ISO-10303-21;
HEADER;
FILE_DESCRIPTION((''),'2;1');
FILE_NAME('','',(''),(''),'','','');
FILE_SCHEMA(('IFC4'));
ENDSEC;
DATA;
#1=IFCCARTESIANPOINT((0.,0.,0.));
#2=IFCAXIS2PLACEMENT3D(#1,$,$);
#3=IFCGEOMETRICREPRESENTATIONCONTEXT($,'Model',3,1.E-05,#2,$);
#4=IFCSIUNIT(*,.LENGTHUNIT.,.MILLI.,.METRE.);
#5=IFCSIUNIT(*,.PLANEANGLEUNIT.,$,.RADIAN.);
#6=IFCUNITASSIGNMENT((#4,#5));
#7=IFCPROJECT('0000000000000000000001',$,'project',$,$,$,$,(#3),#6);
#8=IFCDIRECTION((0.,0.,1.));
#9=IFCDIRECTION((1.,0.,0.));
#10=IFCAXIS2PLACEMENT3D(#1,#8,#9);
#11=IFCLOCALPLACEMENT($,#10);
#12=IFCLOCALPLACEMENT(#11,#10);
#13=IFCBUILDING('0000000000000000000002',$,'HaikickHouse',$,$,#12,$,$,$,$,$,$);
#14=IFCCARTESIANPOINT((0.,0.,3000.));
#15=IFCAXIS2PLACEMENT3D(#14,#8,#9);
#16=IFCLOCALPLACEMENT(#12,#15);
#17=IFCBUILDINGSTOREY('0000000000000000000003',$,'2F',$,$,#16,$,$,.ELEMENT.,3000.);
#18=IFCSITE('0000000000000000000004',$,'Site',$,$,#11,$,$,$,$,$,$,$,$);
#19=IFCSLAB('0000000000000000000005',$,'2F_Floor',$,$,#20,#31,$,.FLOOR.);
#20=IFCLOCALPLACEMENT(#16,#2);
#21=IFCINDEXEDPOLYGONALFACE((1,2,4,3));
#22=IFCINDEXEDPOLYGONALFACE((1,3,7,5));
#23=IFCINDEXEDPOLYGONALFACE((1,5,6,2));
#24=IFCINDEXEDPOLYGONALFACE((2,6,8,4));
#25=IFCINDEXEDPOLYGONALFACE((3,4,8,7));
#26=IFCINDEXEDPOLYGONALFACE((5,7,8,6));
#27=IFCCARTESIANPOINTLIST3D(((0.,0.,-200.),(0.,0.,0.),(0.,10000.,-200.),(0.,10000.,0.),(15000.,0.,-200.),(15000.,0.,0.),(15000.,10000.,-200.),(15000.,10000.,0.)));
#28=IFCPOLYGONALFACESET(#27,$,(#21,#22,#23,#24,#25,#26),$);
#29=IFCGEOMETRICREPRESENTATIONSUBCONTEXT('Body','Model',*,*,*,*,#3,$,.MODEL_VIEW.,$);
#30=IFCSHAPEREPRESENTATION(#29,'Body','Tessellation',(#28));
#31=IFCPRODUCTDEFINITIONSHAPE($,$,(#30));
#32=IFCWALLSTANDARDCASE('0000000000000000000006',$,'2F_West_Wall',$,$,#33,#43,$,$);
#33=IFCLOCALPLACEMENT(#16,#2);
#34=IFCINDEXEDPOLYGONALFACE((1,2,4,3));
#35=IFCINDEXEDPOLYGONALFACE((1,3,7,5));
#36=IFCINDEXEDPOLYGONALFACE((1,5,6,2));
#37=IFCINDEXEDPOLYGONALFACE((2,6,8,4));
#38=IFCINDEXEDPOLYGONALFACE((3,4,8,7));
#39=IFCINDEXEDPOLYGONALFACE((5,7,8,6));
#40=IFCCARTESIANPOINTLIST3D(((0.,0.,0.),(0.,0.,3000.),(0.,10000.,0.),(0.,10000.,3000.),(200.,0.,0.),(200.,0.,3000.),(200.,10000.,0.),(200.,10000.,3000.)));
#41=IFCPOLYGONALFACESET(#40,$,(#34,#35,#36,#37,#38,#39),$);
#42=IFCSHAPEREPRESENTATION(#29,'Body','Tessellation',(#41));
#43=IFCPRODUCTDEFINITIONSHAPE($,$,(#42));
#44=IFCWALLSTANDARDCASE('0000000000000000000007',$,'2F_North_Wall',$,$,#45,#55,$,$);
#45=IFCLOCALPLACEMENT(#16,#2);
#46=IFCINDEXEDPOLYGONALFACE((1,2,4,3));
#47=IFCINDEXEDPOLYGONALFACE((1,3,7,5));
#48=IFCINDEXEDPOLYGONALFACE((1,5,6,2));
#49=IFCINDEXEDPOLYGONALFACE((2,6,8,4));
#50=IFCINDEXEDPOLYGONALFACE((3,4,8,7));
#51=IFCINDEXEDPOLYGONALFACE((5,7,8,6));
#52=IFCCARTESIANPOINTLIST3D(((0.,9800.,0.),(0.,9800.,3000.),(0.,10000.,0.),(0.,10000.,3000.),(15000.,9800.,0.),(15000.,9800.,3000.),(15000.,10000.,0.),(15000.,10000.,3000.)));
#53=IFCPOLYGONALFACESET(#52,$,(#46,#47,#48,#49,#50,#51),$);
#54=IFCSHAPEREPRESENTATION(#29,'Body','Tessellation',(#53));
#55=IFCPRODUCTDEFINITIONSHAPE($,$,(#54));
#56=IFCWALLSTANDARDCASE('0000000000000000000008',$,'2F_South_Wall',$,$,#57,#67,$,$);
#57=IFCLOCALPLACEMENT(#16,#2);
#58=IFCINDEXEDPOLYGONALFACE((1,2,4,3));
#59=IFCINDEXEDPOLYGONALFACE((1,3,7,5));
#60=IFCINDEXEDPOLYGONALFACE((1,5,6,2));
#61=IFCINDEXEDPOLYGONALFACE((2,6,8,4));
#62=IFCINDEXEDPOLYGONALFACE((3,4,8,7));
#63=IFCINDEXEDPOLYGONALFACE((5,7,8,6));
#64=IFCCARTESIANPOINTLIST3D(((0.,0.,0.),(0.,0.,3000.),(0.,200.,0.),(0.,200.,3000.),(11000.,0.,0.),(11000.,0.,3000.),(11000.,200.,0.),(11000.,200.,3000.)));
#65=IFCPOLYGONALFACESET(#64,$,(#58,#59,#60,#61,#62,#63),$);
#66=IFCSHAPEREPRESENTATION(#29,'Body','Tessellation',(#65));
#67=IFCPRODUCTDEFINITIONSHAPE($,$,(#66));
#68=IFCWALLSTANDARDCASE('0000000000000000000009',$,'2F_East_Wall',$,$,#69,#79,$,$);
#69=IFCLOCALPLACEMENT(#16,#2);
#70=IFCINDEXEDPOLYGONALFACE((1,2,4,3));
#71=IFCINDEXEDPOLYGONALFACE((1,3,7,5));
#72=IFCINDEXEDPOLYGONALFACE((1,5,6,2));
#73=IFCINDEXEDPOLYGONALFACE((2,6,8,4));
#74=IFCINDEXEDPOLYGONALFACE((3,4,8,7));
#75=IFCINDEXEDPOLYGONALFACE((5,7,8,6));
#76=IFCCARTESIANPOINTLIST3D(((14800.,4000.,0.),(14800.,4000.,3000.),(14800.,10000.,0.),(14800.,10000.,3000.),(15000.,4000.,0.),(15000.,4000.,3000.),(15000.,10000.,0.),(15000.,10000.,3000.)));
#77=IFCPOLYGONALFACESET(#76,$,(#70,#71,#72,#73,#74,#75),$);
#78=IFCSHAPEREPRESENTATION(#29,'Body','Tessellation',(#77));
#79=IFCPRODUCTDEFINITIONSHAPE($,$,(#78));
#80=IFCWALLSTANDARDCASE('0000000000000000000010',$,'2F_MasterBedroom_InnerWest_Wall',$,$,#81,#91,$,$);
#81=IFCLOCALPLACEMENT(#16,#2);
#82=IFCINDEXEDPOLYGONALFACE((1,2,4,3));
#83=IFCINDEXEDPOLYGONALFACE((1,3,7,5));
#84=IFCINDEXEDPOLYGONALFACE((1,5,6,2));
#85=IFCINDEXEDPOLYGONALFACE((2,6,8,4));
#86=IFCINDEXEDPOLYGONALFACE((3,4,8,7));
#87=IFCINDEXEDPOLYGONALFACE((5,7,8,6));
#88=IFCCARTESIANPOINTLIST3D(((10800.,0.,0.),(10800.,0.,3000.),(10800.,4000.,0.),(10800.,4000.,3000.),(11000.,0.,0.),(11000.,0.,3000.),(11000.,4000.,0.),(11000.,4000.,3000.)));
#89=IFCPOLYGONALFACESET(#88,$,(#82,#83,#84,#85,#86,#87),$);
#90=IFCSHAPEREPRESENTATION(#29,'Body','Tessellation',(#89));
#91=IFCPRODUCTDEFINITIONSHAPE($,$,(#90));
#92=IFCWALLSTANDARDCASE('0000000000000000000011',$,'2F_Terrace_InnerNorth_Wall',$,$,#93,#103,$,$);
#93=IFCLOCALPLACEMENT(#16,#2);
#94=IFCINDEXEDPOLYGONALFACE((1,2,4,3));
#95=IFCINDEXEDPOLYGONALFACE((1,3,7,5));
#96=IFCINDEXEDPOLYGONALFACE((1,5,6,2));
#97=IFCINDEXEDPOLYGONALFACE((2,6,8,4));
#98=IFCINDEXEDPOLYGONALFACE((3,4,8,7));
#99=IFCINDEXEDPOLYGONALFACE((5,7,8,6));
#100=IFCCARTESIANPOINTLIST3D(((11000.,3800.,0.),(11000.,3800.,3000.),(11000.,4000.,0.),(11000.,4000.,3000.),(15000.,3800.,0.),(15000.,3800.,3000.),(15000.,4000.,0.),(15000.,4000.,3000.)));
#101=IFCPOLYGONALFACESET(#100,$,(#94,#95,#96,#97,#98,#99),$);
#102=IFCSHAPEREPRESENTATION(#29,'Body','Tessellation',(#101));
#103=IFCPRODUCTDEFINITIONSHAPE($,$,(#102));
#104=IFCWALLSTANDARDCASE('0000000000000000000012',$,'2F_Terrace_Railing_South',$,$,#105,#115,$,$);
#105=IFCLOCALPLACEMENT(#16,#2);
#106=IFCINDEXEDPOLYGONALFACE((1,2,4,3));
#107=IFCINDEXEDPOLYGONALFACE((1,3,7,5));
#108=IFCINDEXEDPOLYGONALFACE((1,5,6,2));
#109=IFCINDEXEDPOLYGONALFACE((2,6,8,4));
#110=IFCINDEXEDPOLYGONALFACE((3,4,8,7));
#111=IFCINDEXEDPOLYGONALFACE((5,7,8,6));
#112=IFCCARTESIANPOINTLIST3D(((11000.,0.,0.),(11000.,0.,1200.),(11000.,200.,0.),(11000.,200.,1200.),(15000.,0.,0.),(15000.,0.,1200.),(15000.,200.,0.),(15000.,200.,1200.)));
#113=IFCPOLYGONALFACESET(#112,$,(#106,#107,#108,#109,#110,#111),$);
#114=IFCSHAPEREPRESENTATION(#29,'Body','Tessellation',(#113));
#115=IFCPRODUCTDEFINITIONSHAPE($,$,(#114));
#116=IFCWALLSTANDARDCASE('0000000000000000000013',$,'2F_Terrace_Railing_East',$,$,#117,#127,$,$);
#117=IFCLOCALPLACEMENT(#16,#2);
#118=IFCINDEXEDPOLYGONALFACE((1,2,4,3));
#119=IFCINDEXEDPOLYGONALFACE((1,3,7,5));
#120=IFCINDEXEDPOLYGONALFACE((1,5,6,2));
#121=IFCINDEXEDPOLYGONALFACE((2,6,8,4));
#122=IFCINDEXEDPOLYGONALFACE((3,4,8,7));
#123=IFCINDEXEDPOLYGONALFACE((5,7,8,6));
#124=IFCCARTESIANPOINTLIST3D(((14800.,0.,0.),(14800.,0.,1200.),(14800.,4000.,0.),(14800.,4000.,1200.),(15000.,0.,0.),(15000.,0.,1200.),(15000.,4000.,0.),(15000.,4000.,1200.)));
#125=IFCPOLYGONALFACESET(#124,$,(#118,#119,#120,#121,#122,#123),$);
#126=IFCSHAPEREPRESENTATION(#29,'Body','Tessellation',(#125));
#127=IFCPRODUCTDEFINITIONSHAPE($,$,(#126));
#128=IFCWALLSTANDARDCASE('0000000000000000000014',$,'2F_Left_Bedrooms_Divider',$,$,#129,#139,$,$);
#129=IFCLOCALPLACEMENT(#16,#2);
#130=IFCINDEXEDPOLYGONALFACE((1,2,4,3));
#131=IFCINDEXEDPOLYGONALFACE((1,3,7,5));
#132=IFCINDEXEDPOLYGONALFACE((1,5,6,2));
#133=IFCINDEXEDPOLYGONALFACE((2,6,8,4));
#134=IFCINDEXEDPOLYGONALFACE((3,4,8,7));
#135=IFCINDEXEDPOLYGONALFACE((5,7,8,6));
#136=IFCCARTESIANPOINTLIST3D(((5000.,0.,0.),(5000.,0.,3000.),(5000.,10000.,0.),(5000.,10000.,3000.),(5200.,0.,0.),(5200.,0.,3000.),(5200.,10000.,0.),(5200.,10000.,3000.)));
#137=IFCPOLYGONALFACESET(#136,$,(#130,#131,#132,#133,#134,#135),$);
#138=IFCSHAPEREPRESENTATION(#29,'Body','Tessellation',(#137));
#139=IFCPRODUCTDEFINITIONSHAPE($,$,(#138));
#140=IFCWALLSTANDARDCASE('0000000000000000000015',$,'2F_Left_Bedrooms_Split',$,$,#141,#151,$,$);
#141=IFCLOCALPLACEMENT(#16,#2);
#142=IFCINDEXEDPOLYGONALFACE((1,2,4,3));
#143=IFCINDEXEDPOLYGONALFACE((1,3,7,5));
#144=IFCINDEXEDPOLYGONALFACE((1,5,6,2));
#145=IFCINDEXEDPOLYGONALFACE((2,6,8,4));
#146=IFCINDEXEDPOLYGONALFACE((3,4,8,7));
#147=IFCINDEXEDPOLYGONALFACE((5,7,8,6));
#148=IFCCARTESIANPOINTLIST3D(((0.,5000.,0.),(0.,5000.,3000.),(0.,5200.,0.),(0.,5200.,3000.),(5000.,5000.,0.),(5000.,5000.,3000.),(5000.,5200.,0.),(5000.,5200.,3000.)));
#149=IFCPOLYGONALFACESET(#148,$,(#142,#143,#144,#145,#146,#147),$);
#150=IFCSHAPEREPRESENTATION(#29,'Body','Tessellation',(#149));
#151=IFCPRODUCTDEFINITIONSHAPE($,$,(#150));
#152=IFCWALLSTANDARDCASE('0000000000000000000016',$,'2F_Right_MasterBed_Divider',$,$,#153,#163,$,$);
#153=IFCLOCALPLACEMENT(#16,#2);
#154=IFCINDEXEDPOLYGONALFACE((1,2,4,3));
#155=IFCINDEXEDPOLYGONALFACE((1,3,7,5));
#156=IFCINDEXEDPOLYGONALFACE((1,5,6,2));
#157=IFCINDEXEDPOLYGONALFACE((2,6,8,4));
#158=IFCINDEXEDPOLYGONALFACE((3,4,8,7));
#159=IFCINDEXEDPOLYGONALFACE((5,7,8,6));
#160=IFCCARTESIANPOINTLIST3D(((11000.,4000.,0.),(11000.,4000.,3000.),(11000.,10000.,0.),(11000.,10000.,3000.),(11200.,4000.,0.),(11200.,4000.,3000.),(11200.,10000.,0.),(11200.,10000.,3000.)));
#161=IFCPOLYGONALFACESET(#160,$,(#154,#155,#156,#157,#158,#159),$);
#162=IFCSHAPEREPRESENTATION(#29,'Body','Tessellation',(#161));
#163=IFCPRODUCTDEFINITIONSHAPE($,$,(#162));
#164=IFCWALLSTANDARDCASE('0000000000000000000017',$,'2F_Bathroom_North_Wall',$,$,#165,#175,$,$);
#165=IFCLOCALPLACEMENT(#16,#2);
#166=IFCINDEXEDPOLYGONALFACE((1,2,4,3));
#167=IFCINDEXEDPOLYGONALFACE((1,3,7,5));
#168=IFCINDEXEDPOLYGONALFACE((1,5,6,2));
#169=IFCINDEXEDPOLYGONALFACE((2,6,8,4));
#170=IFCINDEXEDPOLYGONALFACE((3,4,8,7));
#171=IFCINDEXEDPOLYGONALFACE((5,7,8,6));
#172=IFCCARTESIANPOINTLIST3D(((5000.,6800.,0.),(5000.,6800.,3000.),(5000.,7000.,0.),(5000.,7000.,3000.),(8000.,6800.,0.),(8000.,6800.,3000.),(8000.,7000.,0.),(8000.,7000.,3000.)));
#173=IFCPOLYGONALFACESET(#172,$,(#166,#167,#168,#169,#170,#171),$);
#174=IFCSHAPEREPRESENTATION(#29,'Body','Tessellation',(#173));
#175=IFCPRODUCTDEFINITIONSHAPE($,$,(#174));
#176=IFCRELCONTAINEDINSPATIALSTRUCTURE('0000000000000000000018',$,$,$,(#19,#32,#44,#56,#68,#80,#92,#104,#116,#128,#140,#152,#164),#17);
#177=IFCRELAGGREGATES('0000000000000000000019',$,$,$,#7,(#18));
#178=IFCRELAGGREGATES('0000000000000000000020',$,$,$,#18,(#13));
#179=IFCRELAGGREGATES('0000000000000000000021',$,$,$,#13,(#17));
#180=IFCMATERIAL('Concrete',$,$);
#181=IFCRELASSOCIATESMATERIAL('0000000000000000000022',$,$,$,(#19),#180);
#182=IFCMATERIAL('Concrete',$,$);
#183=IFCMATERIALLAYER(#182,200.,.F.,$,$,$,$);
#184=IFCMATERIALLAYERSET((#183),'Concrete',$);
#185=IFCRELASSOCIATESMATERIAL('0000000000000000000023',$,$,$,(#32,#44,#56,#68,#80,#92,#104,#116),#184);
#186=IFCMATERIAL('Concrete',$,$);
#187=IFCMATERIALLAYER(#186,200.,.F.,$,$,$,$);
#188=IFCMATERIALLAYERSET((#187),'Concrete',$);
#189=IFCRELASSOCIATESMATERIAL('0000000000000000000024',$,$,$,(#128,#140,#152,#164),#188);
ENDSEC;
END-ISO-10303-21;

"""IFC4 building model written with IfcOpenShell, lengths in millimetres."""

from ifc_helpers import new_model, si_unit, frame, origin, origin_with_axes, place, context, subcontext, project, spatial, rectangle, extrude, material, layer, layer_set, layer_usage, element, save


model = new_model("IFC4")

# Units and contexts
model_context = context("Model", 3, precision=1e-05, world=origin())
body_context = subcontext(model_context, "Body", "Model", "MODEL_VIEW")
ifc_project = project(units=[si_unit("LENGTHUNIT", "METRE", prefix="MILLI"), si_unit("PLANEANGLEUNIT", "RADIAN")], contexts=[model_context])

# Site, building, storey
site_placement = place(None, origin_with_axes())
site = spatial("IfcSite", under=ifc_project, at=site_placement, Name="Site")
building_placement = place(site_placement, origin_with_axes())
building = spatial("IfcBuilding", under=site, at=building_placement, Name="HaikickHouse")
storey_placement = place(building_placement, frame((0.0, 0.0, 3000.0), z_axis=(0.0, 0.0, 1.0), x_axis=(1.0, 0.0, 0.0)))
storey = spatial("IfcBuildingStorey", under=building, at=storey_placement, Name="2F", CompositionType="ELEMENT", Elevation=3000.0)

# Slab
ifc_material_1 = material(Name="Concrete")
slab_placement = place(None, frame((0.0, 0.0, 2800.0), z_axis=(0.0, 0.0, 1.0), x_axis=(1.0, 0.0, 0.0)))
element("IfcSlab", 1, at=slab_placement, inside=storey, material=ifc_material_1, Name="2F_Floor", PredefinedType="FLOOR", context=body_context, shape_type="SweptSolid", body=[
    extrude(rectangle(XDim=15000.0, YDim=10000.0), frame((7500.0, 5000.0, 0.0)), (0.0, 0.0, 1.0), 200.0),
])

# Walls
ifc_material_2 = material(Name="Concrete")
ifc_layer_1 = layer(ifc_material_2, 200.0, ventilated=False)
ifc_layer_set_1 = layer_set([ifc_layer_1], Name="Concrete")
ifc_layer_usage_1 = layer_usage(ifc_layer_set_1, "AXIS2", "POSITIVE", 0.0)
wall_1_placement = place(None, frame((0.0, 0.0, 3000.0), z_axis=(0.0, 0.0, 1.0), x_axis=(1.0, 0.0, 0.0)))
element("IfcWallStandardCase", 2, at=wall_1_placement, inside=storey, material=ifc_layer_usage_1, Name="2F_West_Wall", context=body_context, shape_type="SweptSolid", body=[
    extrude(rectangle(XDim=200.0, YDim=10000.0), frame((100.0, 5000.0, 0.0)), (0.0, 0.0, 1.0), 3000.0),
])
wall_2_placement = place(None, frame((0.0, 9800.0, 3000.0), z_axis=(0.0, 0.0, 1.0), x_axis=(1.0, 0.0, 0.0)))
element("IfcWallStandardCase", 3, at=wall_2_placement, inside=storey, material=ifc_layer_usage_1, Name="2F_North_Wall", context=body_context, shape_type="SweptSolid", body=[
    extrude(rectangle(XDim=15000.0, YDim=200.0), frame((7500.0, 100.0, 0.0)), (0.0, 0.0, 1.0), 3000.0),
])
wall_3_placement = place(None, frame((0.0, 0.0, 3000.0), z_axis=(0.0, 0.0, 1.0), x_axis=(1.0, 0.0, 0.0)))
element("IfcWallStandardCase", 4, at=wall_3_placement, inside=storey, material=ifc_layer_usage_1, Name="2F_South_Wall", context=body_context, shape_type="SweptSolid", body=[
    extrude(rectangle(XDim=11000.0, YDim=200.0), frame((5500.0, 100.0, 0.0)), (0.0, 0.0, 1.0), 3000.0),
])
wall_4_placement = place(None, frame((14800.0, 4000.0, 3000.0), z_axis=(0.0, 0.0, 1.0), x_axis=(1.0, 0.0, 0.0)))
element("IfcWallStandardCase", 5, at=wall_4_placement, inside=storey, material=ifc_layer_usage_1, Name="2F_East_Wall", context=body_context, shape_type="SweptSolid", body=[
    extrude(rectangle(XDim=200.0, YDim=6000.0), frame((100.0, 3000.0, 0.0)), (0.0, 0.0, 1.0), 3000.0),
])
wall_5_placement = place(None, frame((10800.0, 0.0, 3000.0), z_axis=(0.0, 0.0, 1.0), x_axis=(1.0, 0.0, 0.0)))
element("IfcWallStandardCase", 6, at=wall_5_placement, inside=storey, material=ifc_layer_usage_1, Name="2F_MasterBedroom_InnerWest_Wall", context=body_context, shape_type="SweptSolid", body=[
    extrude(rectangle(XDim=200.0, YDim=4000.0), frame((100.0, 2000.0, 0.0)), (0.0, 0.0, 1.0), 3000.0),
])
wall_6_placement = place(None, frame((11000.0, 3800.0, 3000.0), z_axis=(0.0, 0.0, 1.0), x_axis=(1.0, 0.0, 0.0)))
element("IfcWallStandardCase", 7, at=wall_6_placement, inside=storey, material=ifc_layer_usage_1, Name="2F_Terrace_InnerNorth_Wall", context=body_context, shape_type="SweptSolid", body=[
    extrude(rectangle(XDim=4000.0, YDim=200.0), frame((2000.0, 100.0, 0.0)), (0.0, 0.0, 1.0), 3000.0),
])
wall_7_placement = place(None, frame((11000.0, 0.0, 3000.0), z_axis=(0.0, 0.0, 1.0), x_axis=(1.0, 0.0, 0.0)))
element("IfcWallStandardCase", 8, at=wall_7_placement, inside=storey, material=ifc_layer_usage_1, Name="2F_Terrace_Railing_South", context=body_context, shape_type="SweptSolid", body=[
    extrude(rectangle(XDim=4000.0, YDim=200.0), frame((2000.0, 100.0, 0.0)), (0.0, 0.0, 1.0), 1200.0),
])
wall_8_placement = place(None, frame((14800.0, 0.0, 3000.0), z_axis=(0.0, 0.0, 1.0), x_axis=(1.0, 0.0, 0.0)))
element("IfcWallStandardCase", 9, at=wall_8_placement, inside=storey, material=ifc_layer_usage_1, Name="2F_Terrace_Railing_East", context=body_context, shape_type="SweptSolid", body=[
    extrude(rectangle(XDim=200.0, YDim=4000.0), frame((100.0, 2000.0, 0.0)), (0.0, 0.0, 1.0), 1200.0),
])
ifc_material_3 = material(Name="Concrete")
ifc_layer_2 = layer(ifc_material_3, 200.0, ventilated=False)
ifc_layer_set_2 = layer_set([ifc_layer_2], Name="Concrete")
ifc_layer_usage_2 = layer_usage(ifc_layer_set_2, "AXIS2", "POSITIVE", 0.0)
wall_9_placement = place(None, frame((5000.0, 0.0, 3000.0), z_axis=(0.0, 0.0, 1.0), x_axis=(1.0, 0.0, 0.0)))
element("IfcWallStandardCase", 10, at=wall_9_placement, inside=storey, material=ifc_layer_usage_2, Name="2F_Left_Bedrooms_Divider", context=body_context, shape_type="SweptSolid", body=[
    extrude(rectangle(XDim=200.0, YDim=10000.0), frame((100.0, 5000.0, 0.0)), (0.0, 0.0, 1.0), 3000.0),
])
wall_10_placement = place(None, frame((0.0, 5000.0, 3000.0), z_axis=(0.0, 0.0, 1.0), x_axis=(1.0, 0.0, 0.0)))
element("IfcWallStandardCase", 11, at=wall_10_placement, inside=storey, material=ifc_layer_usage_2, Name="2F_Left_Bedrooms_Split", context=body_context, shape_type="SweptSolid", body=[
    extrude(rectangle(XDim=5000.0, YDim=200.0), frame((2500.0, 100.0, 0.0)), (0.0, 0.0, 1.0), 3000.0),
])
wall_11_placement = place(None, frame((11000.0, 4000.0, 3000.0), z_axis=(0.0, 0.0, 1.0), x_axis=(1.0, 0.0, 0.0)))
element("IfcWallStandardCase", 12, at=wall_11_placement, inside=storey, material=ifc_layer_usage_2, Name="2F_Right_MasterBed_Divider", context=body_context, shape_type="SweptSolid", body=[
    extrude(rectangle(XDim=200.0, YDim=6000.0), frame((100.0, 3000.0, 0.0)), (0.0, 0.0, 1.0), 3000.0),
])
wall_12_placement = place(None, frame((5000.0, 6800.0, 3000.0), z_axis=(0.0, 0.0, 1.0), x_axis=(1.0, 0.0, 0.0)))
element("IfcWallStandardCase", 13, at=wall_12_placement, inside=storey, material=ifc_layer_usage_2, Name="2F_Bathroom_North_Wall", context=body_context, shape_type="SweptSolid", body=[
    extrude(rectangle(XDim=3000.0, YDim=200.0), frame((1500.0, 100.0, 0.0)), (0.0, 0.0, 1.0), 3000.0),
])

save(model, "model.ifc")
